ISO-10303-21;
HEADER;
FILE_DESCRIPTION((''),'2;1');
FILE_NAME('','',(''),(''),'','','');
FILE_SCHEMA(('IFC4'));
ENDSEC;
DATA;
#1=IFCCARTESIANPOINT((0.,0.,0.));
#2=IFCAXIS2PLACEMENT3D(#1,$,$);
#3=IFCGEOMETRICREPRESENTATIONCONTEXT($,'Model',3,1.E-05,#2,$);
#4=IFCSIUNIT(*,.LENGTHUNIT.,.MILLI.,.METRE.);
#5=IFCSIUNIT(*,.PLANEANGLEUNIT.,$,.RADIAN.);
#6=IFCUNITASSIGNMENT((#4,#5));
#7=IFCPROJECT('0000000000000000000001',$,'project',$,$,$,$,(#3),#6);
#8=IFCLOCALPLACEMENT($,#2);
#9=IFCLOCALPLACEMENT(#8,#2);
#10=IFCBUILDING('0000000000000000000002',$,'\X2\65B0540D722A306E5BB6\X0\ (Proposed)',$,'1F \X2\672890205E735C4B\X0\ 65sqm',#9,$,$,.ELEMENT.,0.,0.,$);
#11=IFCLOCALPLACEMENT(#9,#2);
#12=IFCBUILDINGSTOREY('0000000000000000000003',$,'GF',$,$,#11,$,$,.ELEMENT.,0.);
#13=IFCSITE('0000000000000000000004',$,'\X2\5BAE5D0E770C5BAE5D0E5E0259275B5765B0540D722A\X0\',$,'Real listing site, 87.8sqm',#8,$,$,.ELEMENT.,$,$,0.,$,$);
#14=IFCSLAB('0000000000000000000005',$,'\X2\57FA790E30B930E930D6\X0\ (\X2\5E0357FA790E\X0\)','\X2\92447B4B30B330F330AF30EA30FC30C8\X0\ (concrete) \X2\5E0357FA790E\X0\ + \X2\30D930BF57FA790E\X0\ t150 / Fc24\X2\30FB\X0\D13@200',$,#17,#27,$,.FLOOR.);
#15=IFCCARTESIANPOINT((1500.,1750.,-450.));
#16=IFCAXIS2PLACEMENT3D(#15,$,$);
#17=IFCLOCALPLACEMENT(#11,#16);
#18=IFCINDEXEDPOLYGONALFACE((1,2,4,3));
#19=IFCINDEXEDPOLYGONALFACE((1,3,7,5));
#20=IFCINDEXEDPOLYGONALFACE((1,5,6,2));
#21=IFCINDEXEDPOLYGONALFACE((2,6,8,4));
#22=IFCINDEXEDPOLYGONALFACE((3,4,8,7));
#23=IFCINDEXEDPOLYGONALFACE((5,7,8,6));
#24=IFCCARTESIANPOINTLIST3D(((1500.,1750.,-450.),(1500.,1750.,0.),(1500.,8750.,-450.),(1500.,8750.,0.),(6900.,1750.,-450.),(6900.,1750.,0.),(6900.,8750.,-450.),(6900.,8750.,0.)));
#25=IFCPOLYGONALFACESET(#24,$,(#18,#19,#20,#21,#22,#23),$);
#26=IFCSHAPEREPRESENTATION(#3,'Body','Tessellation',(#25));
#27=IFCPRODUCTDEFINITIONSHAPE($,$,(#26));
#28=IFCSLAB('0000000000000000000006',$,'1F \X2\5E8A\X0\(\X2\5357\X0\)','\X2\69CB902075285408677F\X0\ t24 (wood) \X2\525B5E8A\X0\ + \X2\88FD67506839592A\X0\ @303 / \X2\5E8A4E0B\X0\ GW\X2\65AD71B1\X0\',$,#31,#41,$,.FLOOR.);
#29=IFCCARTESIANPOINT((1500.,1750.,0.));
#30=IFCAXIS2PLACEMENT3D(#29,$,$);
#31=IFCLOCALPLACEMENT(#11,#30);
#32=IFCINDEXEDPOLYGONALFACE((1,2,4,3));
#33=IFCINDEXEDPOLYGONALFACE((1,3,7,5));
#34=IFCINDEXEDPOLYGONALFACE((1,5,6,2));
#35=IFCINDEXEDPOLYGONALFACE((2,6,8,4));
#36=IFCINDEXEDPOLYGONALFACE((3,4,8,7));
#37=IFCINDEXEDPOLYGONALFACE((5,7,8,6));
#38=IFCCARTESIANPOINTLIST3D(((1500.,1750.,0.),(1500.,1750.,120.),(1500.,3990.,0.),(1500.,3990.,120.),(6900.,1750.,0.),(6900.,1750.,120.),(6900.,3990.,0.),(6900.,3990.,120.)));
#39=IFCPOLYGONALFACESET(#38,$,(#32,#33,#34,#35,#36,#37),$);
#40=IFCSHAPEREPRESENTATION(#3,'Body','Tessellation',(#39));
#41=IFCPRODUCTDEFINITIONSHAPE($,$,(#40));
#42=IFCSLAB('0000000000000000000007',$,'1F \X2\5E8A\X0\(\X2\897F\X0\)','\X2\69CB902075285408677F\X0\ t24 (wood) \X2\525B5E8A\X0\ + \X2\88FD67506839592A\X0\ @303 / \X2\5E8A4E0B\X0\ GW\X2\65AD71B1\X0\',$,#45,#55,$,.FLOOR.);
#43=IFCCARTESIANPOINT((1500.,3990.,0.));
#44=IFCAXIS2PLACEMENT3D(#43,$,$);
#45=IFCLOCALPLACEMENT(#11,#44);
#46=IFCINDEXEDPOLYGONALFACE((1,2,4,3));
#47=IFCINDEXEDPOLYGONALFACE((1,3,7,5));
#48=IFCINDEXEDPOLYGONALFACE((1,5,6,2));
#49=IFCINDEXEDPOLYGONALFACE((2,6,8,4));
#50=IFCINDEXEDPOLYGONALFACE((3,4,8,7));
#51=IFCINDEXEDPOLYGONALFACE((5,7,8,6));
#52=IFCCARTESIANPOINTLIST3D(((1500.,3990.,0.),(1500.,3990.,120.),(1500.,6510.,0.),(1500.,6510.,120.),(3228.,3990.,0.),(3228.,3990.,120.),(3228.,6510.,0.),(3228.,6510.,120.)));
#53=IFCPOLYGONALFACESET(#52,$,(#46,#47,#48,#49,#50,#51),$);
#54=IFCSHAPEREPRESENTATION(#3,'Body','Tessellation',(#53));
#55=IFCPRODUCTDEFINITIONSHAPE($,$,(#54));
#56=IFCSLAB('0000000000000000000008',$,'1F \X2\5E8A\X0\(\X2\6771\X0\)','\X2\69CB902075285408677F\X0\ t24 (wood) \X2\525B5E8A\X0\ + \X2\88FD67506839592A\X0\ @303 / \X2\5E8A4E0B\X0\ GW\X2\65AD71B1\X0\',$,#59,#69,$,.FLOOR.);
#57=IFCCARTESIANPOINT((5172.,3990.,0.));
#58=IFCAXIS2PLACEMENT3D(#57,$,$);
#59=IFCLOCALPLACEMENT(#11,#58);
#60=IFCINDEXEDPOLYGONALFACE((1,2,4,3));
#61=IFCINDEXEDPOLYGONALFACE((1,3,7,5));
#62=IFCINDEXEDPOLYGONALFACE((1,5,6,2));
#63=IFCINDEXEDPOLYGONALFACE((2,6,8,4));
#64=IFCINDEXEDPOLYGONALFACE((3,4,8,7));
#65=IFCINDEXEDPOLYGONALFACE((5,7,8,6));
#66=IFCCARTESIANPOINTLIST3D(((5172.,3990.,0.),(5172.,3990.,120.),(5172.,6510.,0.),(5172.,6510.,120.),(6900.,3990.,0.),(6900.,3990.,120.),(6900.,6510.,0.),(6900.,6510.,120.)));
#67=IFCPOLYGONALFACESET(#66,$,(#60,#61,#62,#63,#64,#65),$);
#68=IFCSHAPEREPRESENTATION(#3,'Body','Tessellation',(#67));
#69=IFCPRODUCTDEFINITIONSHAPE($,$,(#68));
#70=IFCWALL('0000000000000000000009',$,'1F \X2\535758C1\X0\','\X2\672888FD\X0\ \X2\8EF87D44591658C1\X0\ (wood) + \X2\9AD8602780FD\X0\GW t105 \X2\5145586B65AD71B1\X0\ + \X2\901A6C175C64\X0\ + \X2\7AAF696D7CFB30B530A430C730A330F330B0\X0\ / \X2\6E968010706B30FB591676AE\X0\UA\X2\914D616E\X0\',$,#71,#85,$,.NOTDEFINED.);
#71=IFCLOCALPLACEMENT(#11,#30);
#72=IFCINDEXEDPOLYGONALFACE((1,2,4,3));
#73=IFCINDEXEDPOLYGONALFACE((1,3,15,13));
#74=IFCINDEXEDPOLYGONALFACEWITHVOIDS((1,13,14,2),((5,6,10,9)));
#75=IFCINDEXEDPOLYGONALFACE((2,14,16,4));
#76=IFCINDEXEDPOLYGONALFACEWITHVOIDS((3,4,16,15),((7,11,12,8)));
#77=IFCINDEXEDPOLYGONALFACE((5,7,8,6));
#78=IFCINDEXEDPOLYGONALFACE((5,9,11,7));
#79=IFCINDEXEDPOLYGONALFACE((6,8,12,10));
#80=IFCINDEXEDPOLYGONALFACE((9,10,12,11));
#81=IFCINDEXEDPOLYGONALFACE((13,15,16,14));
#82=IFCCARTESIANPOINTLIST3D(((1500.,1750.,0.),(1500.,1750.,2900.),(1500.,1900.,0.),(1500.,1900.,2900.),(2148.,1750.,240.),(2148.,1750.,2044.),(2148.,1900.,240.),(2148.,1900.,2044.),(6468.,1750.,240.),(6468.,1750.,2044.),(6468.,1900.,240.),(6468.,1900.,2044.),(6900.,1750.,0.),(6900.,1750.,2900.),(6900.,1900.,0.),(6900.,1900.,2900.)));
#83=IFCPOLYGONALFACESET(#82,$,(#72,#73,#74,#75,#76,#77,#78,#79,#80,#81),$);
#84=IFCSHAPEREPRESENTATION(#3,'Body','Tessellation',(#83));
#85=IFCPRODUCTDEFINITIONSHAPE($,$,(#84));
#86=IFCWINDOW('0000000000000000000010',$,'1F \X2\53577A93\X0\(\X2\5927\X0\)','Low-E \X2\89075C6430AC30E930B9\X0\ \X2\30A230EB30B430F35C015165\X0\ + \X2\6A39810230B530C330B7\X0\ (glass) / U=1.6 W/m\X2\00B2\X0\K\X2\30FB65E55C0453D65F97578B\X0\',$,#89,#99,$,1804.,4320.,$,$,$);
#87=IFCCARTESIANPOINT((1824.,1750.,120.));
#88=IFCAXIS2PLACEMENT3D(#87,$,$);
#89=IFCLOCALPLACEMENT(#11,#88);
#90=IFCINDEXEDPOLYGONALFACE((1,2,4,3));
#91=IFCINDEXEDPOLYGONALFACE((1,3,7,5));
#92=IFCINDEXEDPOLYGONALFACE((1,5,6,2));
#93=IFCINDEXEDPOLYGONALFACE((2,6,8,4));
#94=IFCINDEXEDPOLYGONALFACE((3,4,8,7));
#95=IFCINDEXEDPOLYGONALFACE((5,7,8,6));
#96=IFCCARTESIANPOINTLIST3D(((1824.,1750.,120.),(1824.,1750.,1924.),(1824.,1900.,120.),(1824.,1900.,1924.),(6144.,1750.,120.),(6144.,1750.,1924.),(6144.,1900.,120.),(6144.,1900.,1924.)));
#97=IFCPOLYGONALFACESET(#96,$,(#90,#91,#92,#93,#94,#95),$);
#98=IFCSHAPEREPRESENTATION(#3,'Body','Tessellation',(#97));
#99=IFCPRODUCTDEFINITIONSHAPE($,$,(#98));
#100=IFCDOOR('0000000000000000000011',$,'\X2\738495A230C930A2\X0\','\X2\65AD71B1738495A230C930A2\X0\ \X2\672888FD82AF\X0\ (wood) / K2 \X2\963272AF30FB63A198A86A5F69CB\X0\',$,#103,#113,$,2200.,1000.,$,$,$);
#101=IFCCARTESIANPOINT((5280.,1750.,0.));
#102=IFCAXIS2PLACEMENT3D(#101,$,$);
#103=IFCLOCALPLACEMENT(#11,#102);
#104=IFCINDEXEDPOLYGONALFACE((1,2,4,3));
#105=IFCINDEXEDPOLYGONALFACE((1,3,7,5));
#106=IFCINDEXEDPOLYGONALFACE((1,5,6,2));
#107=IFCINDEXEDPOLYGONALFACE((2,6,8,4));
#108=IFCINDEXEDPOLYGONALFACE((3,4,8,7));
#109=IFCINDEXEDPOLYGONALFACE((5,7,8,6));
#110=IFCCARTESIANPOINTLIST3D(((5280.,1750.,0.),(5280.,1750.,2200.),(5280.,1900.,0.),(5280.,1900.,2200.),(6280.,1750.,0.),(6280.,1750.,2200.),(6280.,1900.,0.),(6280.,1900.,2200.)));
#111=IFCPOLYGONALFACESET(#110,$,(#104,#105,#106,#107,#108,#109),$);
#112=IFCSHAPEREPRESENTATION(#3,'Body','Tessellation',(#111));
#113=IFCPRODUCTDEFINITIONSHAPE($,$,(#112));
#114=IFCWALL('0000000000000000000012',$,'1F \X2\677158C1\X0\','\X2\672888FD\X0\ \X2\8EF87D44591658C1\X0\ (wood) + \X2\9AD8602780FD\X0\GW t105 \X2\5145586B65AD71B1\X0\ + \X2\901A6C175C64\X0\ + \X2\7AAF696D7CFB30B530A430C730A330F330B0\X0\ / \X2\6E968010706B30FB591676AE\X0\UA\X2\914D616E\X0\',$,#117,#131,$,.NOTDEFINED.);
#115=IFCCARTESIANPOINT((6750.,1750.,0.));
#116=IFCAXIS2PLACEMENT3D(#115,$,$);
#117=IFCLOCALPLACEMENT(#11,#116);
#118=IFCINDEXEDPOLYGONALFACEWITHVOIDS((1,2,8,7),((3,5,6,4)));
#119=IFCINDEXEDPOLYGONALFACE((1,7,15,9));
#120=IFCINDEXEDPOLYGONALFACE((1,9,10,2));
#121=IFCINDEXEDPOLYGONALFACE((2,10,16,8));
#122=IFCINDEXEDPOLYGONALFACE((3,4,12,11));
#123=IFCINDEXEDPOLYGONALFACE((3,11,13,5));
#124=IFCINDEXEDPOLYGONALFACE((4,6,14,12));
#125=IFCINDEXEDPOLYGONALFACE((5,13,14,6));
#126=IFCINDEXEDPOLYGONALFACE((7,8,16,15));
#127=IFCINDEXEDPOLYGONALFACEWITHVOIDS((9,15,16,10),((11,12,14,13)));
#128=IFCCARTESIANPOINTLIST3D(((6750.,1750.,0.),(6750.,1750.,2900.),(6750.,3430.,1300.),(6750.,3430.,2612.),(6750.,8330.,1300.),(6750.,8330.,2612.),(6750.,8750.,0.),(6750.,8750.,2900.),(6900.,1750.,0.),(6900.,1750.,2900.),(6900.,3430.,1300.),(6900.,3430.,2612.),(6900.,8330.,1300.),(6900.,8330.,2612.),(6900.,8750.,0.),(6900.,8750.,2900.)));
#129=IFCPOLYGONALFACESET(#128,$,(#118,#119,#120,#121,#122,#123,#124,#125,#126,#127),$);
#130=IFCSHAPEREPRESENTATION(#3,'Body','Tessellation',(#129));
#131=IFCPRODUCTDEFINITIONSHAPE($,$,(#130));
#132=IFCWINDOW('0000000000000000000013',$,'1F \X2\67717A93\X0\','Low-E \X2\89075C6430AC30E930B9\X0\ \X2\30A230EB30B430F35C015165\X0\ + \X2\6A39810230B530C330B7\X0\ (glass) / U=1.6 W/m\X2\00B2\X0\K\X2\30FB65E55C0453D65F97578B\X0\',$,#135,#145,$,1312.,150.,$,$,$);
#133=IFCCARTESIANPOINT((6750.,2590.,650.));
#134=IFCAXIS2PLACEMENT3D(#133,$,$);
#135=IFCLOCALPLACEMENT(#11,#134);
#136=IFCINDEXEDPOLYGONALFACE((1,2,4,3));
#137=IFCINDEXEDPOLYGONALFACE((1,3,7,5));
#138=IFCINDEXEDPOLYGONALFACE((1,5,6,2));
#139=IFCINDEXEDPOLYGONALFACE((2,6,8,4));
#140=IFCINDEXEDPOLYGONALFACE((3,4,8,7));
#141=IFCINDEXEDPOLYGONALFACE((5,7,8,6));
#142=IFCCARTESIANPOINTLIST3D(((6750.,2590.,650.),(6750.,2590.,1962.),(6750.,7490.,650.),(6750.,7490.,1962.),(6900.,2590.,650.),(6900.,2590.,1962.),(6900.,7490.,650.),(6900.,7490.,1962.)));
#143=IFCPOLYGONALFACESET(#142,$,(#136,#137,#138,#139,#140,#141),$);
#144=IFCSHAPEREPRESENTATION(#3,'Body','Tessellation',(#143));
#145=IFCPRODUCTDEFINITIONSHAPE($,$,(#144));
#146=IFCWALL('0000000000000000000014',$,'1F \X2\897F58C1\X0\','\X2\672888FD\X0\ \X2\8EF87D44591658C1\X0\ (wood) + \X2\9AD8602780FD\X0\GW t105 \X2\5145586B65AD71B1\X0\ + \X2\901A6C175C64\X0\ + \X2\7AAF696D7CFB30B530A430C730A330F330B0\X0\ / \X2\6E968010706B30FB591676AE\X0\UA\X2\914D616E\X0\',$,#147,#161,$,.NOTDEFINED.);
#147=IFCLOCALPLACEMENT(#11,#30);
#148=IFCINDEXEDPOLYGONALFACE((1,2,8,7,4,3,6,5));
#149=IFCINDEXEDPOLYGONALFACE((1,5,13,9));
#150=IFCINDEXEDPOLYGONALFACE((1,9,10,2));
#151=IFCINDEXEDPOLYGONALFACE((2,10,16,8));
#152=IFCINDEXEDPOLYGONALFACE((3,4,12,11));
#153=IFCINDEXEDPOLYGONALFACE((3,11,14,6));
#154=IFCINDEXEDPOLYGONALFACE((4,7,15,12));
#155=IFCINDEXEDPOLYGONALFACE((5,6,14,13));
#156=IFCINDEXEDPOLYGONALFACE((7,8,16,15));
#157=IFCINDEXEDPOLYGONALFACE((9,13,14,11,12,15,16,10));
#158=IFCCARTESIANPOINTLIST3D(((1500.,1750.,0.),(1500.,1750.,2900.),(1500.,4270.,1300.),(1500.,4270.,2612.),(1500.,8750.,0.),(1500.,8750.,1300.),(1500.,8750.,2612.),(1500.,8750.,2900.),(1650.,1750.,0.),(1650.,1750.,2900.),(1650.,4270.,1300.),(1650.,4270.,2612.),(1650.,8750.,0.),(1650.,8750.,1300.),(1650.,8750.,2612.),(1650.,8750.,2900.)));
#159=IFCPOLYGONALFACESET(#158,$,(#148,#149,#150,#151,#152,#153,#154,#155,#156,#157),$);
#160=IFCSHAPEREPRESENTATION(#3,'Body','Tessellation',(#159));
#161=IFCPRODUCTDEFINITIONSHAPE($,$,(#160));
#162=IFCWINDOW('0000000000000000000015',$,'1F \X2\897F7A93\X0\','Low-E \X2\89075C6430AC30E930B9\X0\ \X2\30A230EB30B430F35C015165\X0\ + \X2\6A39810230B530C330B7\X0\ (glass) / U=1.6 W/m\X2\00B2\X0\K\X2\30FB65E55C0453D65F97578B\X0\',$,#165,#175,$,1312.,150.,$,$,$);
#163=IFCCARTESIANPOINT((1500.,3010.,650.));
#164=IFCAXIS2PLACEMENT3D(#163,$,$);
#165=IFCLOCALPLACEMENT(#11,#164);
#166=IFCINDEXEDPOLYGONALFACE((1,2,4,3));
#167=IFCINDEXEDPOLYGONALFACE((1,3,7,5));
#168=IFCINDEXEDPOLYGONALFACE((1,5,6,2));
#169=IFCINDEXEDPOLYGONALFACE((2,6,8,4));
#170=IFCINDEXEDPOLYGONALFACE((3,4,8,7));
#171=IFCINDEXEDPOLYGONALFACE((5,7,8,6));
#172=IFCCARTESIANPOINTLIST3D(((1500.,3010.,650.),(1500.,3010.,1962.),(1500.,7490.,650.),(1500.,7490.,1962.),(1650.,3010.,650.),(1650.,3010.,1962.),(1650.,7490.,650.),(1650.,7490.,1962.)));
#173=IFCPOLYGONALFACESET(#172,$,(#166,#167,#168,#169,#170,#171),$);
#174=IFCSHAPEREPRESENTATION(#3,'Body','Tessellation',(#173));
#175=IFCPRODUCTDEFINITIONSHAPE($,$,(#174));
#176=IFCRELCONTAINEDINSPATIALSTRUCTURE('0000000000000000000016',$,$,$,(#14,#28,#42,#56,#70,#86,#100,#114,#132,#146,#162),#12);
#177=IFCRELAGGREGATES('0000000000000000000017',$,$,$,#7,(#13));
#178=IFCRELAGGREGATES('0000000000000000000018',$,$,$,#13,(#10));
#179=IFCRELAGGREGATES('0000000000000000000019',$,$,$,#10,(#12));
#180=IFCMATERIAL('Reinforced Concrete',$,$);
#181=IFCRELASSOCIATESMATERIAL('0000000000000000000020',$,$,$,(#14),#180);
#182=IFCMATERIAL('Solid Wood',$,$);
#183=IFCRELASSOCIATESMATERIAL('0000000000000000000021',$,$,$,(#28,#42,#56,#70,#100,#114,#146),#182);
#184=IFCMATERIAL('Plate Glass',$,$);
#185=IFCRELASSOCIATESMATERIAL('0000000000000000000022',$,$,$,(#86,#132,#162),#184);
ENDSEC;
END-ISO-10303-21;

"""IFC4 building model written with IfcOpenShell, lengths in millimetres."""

from ifc_helpers import new_model, si_unit, frame, frame_2d, origin, place, context, project, spatial, rectangle, extrude, material, element, fill, save


model = new_model("IFC4")

# Units and contexts
model_context = context("Model", 3, precision=1e-05, world=origin())
ifc_project = project(units=[si_unit("LENGTHUNIT", "METRE", prefix="MILLI"), si_unit("PLANEANGLEUNIT", "RADIAN")], contexts=[model_context])

# Site, building, storey
site_placement = place(None, origin())
site = spatial("IfcSite", under=ifc_project, at=site_placement, Name="宮崎県宮崎市大字新名爪", ObjectType="Real listing site, 87.8sqm", CompositionType="ELEMENT", RefElevation=0.0)
building_placement = place(site_placement, origin())
building = spatial("IfcBuilding", under=site, at=building_placement, Name="新名爪の家 (Proposed)", ObjectType="1F 木造平屋 65sqm", CompositionType="ELEMENT", ElevationOfRefHeight=0.0, ElevationOfTerrain=0.0)
storey_placement = place(building_placement, origin())
storey = spatial("IfcBuildingStorey", under=building, at=storey_placement, Name="GF", CompositionType="ELEMENT", Elevation=0.0)

# Slabs
ifc_material_1 = material(Name="Reinforced Concrete")
slab_1_placement = place(storey_placement, frame((1500.0, 1750.0, -450.0)))
element("IfcSlab", 1, at=slab_1_placement, inside=storey, material=ifc_material_1, Name="基礎スラブ (布基礎)", Description="鉄筋コンクリート (concrete) 布基礎 + ベタ基礎 t150 / Fc24・D13@200", PredefinedType="FLOOR", context=model_context, shape_type="SweptSolid", body=[
    extrude(rectangle(XDim=5400.0, YDim=7000.0, at=frame_2d((2700.0, 3500.0))), frame((1500.0, 1750.0, -450.0)), (0.0, 0.0, 1.0), 450.0),
])
ifc_material_2 = material(Name="Solid Wood")
slab_2_placement = place(storey_placement, frame((1500.0, 1750.0, 0.0)))
element("IfcSlab", 2, at=slab_2_placement, inside=storey, material=ifc_material_2, Name="1F 床(南)", Description="構造用合板 t24 (wood) 剛床 + 製材根太 @303 / 床下 GW断熱", PredefinedType="FLOOR", context=model_context, shape_type="SweptSolid", body=[
    extrude(rectangle(XDim=5400.0, YDim=2240.0, at=frame_2d((2700.0, 1120.0))), frame((1500.0, 1750.0, 0.0)), (0.0, 0.0, 1.0), 120.0),
])
slab_3_placement = place(storey_placement, frame((1500.0, 3990.0, 0.0)))
element("IfcSlab", 3, at=slab_3_placement, inside=storey, material=ifc_material_2, Name="1F 床(西)", Description="構造用合板 t24 (wood) 剛床 + 製材根太 @303 / 床下 GW断熱", PredefinedType="FLOOR", context=model_context, shape_type="SweptSolid", body=[
    extrude(rectangle(XDim=1728.0, YDim=2520.0, at=frame_2d((864.0, 1260.0))), frame((1500.0, 3990.0, 0.0)), (0.0, 0.0, 1.0), 120.0),
])
slab_4_placement = place(storey_placement, frame((5172.0, 3990.0, 0.0)))
element("IfcSlab", 4, at=slab_4_placement, inside=storey, material=ifc_material_2, Name="1F 床(東)", Description="構造用合板 t24 (wood) 剛床 + 製材根太 @303 / 床下 GW断熱", PredefinedType="FLOOR", context=model_context, shape_type="SweptSolid", body=[
    extrude(rectangle(XDim=1728.0, YDim=2520.0, at=frame_2d((864.0, 1260.0))), frame((5172.0, 3990.0, 0.0)), (0.0, 0.0, 1.0), 120.0),
])

# Wall, openings, window, door
wall_1_placement = place(storey_placement, frame((1500.0, 1750.0, 0.0)))
wall_1 = element("IfcWall", 5, at=wall_1_placement, inside=storey, material=ifc_material_2, Name="1F 南壁", Description="木製 軸組外壁 (wood) + 高性能GW t105 充填断熱 + 通気層 + 窯業系サイディング / 準耐火・外皮UA配慮", PredefinedType="NOTDEFINED", context=model_context, shape_type="SweptSolid", body=[
    extrude(rectangle(XDim=5400.0, YDim=150.0, at=frame_2d((2700.0, 75.0))), frame((1500.0, 1750.0, 0.0)), (0.0, 0.0, 1.0), 2900.0),
])
opening_1_placement = place(storey_placement, frame((1824.0, 1750.0, 120.0)))
opening_1 = element("IfcOpeningElement", 6, at=opening_1_placement, cuts=wall_1, PredefinedType="NOTDEFINED", context=model_context, shape_type="SweptSolid", body=[
    extrude(rectangle(XDim=4320.0, YDim=150.0, at=frame_2d((2160.0, 75.0))), frame((1824.0, 1750.0, 120.0)), (0.0, 0.0, 1.0), 1804.0),
])
opening_2_placement = place(storey_placement, frame((5280.0, 1750.0, 0.0)))
opening_2 = element("IfcOpeningElement", 7, at=opening_2_placement, cuts=wall_1, PredefinedType="NOTDEFINED", context=model_context, shape_type="SweptSolid", body=[
    extrude(rectangle(XDim=1000.0, YDim=150.0, at=frame_2d((500.0, 75.0))), frame((5280.0, 1750.0, 0.0)), (0.0, 0.0, 1.0), 2200.0),
])
ifc_material_3 = material(Name="Plate Glass")
window_1_placement = place(storey_placement, frame((1824.0, 1750.0, 120.0)))
window_1 = element("IfcWindow", 8, at=window_1_placement, inside=storey, material=ifc_material_3, Name="1F 南窓(大)", Description="Low-E 複層ガラス アルゴン封入 + 樹脂サッシ (glass) / U=1.6 W/m²K・日射取得型", OverallHeight=1804.0, OverallWidth=4320.0, context=model_context, shape_type="SweptSolid", body=[
    extrude(rectangle(XDim=4320.0, YDim=150.0, at=frame_2d((2160.0, 75.0))), frame((1824.0, 1750.0, 120.0)), (0.0, 0.0, 1.0), 1804.0),
])
fill(opening_1, window_1)
door_placement = place(storey_placement, frame((5280.0, 1750.0, 0.0)))
door = element("IfcDoor", 9, at=door_placement, inside=storey, material=ifc_material_2, Name="玄関ドア", Description="断熱玄関ドア 木製芯 (wood) / K2 防犯・採風機構", OverallHeight=2200.0, OverallWidth=1000.0, context=model_context, shape_type="SweptSolid", body=[
    extrude(rectangle(XDim=1000.0, YDim=150.0, at=frame_2d((500.0, 75.0))), frame((5280.0, 1750.0, 0.0)), (0.0, 0.0, 1.0), 2200.0),
])
fill(opening_2, door)

# Walls, openings, windows
wall_2_placement = place(storey_placement, frame((6750.0, 1750.0, 0.0)))
wall_2 = element("IfcWall", 10, at=wall_2_placement, inside=storey, material=ifc_material_2, Name="1F 東壁", Description="木製 軸組外壁 (wood) + 高性能GW t105 充填断熱 + 通気層 + 窯業系サイディング / 準耐火・外皮UA配慮", PredefinedType="NOTDEFINED", context=model_context, shape_type="SweptSolid", body=[
    extrude(rectangle(XDim=150.0, YDim=7000.0, at=frame_2d((75.0, 3500.0))), frame((6750.0, 1750.0, 0.0)), (0.0, 0.0, 1.0), 2900.0),
])
opening_3_placement = place(storey_placement, frame((6750.0, 2590.0, 650.0)))
opening_3 = element("IfcOpeningElement", 11, at=opening_3_placement, cuts=wall_2, PredefinedType="NOTDEFINED", context=model_context, shape_type="SweptSolid", body=[
    extrude(rectangle(XDim=150.0, YDim=4900.0, at=frame_2d((75.0, 2450.0))), frame((6750.0, 2590.0, 650.0)), (0.0, 0.0, 1.0), 1312.0),
])
window_2_placement = place(storey_placement, frame((6750.0, 2590.0, 650.0)))
window_2 = element("IfcWindow", 12, at=window_2_placement, inside=storey, material=ifc_material_3, Name="1F 東窓", Description="Low-E 複層ガラス アルゴン封入 + 樹脂サッシ (glass) / U=1.6 W/m²K・日射取得型", OverallHeight=1312.0, OverallWidth=150.0, context=model_context, shape_type="SweptSolid", body=[
    extrude(rectangle(XDim=150.0, YDim=4900.0, at=frame_2d((75.0, 2450.0))), frame((6750.0, 2590.0, 650.0)), (0.0, 0.0, 1.0), 1312.0),
])
fill(opening_3, window_2)
wall_3_placement = place(storey_placement, frame((1500.0, 1750.0, 0.0)))
wall_3 = element("IfcWall", 13, at=wall_3_placement, inside=storey, material=ifc_material_2, Name="1F 西壁", Description="木製 軸組外壁 (wood) + 高性能GW t105 充填断熱 + 通気層 + 窯業系サイディング / 準耐火・外皮UA配慮", PredefinedType="NOTDEFINED", context=model_context, shape_type="SweptSolid", body=[
    extrude(rectangle(XDim=150.0, YDim=7000.0, at=frame_2d((75.0, 3500.0))), frame((1500.0, 1750.0, 0.0)), (0.0, 0.0, 1.0), 2900.0),
])
opening_4_placement = place(storey_placement, frame((1500.0, 3010.0, 650.0)))
opening_4 = element("IfcOpeningElement", 14, at=opening_4_placement, cuts=wall_3, PredefinedType="NOTDEFINED", context=model_context, shape_type="SweptSolid", body=[
    extrude(rectangle(XDim=150.0, YDim=4480.0, at=frame_2d((75.0, 2240.0))), frame((1500.0, 3010.0, 650.0)), (0.0, 0.0, 1.0), 1312.0),
])
window_3_placement = place(storey_placement, frame((1500.0, 3010.0, 650.0)))
window_3 = element("IfcWindow", 15, at=window_3_placement, inside=storey, material=ifc_material_3, Name="1F 西窓", Description="Low-E 複層ガラス アルゴン封入 + 樹脂サッシ (glass) / U=1.6 W/m²K・日射取得型", OverallHeight=1312.0, OverallWidth=150.0, context=model_context, shape_type="SweptSolid", body=[
    extrude(rectangle(XDim=150.0, YDim=4480.0, at=frame_2d((75.0, 2240.0))), frame((1500.0, 3010.0, 650.0)), (0.0, 0.0, 1.0), 1312.0),
])
fill(opening_4, window_3)

save(model, "model.ifc")
